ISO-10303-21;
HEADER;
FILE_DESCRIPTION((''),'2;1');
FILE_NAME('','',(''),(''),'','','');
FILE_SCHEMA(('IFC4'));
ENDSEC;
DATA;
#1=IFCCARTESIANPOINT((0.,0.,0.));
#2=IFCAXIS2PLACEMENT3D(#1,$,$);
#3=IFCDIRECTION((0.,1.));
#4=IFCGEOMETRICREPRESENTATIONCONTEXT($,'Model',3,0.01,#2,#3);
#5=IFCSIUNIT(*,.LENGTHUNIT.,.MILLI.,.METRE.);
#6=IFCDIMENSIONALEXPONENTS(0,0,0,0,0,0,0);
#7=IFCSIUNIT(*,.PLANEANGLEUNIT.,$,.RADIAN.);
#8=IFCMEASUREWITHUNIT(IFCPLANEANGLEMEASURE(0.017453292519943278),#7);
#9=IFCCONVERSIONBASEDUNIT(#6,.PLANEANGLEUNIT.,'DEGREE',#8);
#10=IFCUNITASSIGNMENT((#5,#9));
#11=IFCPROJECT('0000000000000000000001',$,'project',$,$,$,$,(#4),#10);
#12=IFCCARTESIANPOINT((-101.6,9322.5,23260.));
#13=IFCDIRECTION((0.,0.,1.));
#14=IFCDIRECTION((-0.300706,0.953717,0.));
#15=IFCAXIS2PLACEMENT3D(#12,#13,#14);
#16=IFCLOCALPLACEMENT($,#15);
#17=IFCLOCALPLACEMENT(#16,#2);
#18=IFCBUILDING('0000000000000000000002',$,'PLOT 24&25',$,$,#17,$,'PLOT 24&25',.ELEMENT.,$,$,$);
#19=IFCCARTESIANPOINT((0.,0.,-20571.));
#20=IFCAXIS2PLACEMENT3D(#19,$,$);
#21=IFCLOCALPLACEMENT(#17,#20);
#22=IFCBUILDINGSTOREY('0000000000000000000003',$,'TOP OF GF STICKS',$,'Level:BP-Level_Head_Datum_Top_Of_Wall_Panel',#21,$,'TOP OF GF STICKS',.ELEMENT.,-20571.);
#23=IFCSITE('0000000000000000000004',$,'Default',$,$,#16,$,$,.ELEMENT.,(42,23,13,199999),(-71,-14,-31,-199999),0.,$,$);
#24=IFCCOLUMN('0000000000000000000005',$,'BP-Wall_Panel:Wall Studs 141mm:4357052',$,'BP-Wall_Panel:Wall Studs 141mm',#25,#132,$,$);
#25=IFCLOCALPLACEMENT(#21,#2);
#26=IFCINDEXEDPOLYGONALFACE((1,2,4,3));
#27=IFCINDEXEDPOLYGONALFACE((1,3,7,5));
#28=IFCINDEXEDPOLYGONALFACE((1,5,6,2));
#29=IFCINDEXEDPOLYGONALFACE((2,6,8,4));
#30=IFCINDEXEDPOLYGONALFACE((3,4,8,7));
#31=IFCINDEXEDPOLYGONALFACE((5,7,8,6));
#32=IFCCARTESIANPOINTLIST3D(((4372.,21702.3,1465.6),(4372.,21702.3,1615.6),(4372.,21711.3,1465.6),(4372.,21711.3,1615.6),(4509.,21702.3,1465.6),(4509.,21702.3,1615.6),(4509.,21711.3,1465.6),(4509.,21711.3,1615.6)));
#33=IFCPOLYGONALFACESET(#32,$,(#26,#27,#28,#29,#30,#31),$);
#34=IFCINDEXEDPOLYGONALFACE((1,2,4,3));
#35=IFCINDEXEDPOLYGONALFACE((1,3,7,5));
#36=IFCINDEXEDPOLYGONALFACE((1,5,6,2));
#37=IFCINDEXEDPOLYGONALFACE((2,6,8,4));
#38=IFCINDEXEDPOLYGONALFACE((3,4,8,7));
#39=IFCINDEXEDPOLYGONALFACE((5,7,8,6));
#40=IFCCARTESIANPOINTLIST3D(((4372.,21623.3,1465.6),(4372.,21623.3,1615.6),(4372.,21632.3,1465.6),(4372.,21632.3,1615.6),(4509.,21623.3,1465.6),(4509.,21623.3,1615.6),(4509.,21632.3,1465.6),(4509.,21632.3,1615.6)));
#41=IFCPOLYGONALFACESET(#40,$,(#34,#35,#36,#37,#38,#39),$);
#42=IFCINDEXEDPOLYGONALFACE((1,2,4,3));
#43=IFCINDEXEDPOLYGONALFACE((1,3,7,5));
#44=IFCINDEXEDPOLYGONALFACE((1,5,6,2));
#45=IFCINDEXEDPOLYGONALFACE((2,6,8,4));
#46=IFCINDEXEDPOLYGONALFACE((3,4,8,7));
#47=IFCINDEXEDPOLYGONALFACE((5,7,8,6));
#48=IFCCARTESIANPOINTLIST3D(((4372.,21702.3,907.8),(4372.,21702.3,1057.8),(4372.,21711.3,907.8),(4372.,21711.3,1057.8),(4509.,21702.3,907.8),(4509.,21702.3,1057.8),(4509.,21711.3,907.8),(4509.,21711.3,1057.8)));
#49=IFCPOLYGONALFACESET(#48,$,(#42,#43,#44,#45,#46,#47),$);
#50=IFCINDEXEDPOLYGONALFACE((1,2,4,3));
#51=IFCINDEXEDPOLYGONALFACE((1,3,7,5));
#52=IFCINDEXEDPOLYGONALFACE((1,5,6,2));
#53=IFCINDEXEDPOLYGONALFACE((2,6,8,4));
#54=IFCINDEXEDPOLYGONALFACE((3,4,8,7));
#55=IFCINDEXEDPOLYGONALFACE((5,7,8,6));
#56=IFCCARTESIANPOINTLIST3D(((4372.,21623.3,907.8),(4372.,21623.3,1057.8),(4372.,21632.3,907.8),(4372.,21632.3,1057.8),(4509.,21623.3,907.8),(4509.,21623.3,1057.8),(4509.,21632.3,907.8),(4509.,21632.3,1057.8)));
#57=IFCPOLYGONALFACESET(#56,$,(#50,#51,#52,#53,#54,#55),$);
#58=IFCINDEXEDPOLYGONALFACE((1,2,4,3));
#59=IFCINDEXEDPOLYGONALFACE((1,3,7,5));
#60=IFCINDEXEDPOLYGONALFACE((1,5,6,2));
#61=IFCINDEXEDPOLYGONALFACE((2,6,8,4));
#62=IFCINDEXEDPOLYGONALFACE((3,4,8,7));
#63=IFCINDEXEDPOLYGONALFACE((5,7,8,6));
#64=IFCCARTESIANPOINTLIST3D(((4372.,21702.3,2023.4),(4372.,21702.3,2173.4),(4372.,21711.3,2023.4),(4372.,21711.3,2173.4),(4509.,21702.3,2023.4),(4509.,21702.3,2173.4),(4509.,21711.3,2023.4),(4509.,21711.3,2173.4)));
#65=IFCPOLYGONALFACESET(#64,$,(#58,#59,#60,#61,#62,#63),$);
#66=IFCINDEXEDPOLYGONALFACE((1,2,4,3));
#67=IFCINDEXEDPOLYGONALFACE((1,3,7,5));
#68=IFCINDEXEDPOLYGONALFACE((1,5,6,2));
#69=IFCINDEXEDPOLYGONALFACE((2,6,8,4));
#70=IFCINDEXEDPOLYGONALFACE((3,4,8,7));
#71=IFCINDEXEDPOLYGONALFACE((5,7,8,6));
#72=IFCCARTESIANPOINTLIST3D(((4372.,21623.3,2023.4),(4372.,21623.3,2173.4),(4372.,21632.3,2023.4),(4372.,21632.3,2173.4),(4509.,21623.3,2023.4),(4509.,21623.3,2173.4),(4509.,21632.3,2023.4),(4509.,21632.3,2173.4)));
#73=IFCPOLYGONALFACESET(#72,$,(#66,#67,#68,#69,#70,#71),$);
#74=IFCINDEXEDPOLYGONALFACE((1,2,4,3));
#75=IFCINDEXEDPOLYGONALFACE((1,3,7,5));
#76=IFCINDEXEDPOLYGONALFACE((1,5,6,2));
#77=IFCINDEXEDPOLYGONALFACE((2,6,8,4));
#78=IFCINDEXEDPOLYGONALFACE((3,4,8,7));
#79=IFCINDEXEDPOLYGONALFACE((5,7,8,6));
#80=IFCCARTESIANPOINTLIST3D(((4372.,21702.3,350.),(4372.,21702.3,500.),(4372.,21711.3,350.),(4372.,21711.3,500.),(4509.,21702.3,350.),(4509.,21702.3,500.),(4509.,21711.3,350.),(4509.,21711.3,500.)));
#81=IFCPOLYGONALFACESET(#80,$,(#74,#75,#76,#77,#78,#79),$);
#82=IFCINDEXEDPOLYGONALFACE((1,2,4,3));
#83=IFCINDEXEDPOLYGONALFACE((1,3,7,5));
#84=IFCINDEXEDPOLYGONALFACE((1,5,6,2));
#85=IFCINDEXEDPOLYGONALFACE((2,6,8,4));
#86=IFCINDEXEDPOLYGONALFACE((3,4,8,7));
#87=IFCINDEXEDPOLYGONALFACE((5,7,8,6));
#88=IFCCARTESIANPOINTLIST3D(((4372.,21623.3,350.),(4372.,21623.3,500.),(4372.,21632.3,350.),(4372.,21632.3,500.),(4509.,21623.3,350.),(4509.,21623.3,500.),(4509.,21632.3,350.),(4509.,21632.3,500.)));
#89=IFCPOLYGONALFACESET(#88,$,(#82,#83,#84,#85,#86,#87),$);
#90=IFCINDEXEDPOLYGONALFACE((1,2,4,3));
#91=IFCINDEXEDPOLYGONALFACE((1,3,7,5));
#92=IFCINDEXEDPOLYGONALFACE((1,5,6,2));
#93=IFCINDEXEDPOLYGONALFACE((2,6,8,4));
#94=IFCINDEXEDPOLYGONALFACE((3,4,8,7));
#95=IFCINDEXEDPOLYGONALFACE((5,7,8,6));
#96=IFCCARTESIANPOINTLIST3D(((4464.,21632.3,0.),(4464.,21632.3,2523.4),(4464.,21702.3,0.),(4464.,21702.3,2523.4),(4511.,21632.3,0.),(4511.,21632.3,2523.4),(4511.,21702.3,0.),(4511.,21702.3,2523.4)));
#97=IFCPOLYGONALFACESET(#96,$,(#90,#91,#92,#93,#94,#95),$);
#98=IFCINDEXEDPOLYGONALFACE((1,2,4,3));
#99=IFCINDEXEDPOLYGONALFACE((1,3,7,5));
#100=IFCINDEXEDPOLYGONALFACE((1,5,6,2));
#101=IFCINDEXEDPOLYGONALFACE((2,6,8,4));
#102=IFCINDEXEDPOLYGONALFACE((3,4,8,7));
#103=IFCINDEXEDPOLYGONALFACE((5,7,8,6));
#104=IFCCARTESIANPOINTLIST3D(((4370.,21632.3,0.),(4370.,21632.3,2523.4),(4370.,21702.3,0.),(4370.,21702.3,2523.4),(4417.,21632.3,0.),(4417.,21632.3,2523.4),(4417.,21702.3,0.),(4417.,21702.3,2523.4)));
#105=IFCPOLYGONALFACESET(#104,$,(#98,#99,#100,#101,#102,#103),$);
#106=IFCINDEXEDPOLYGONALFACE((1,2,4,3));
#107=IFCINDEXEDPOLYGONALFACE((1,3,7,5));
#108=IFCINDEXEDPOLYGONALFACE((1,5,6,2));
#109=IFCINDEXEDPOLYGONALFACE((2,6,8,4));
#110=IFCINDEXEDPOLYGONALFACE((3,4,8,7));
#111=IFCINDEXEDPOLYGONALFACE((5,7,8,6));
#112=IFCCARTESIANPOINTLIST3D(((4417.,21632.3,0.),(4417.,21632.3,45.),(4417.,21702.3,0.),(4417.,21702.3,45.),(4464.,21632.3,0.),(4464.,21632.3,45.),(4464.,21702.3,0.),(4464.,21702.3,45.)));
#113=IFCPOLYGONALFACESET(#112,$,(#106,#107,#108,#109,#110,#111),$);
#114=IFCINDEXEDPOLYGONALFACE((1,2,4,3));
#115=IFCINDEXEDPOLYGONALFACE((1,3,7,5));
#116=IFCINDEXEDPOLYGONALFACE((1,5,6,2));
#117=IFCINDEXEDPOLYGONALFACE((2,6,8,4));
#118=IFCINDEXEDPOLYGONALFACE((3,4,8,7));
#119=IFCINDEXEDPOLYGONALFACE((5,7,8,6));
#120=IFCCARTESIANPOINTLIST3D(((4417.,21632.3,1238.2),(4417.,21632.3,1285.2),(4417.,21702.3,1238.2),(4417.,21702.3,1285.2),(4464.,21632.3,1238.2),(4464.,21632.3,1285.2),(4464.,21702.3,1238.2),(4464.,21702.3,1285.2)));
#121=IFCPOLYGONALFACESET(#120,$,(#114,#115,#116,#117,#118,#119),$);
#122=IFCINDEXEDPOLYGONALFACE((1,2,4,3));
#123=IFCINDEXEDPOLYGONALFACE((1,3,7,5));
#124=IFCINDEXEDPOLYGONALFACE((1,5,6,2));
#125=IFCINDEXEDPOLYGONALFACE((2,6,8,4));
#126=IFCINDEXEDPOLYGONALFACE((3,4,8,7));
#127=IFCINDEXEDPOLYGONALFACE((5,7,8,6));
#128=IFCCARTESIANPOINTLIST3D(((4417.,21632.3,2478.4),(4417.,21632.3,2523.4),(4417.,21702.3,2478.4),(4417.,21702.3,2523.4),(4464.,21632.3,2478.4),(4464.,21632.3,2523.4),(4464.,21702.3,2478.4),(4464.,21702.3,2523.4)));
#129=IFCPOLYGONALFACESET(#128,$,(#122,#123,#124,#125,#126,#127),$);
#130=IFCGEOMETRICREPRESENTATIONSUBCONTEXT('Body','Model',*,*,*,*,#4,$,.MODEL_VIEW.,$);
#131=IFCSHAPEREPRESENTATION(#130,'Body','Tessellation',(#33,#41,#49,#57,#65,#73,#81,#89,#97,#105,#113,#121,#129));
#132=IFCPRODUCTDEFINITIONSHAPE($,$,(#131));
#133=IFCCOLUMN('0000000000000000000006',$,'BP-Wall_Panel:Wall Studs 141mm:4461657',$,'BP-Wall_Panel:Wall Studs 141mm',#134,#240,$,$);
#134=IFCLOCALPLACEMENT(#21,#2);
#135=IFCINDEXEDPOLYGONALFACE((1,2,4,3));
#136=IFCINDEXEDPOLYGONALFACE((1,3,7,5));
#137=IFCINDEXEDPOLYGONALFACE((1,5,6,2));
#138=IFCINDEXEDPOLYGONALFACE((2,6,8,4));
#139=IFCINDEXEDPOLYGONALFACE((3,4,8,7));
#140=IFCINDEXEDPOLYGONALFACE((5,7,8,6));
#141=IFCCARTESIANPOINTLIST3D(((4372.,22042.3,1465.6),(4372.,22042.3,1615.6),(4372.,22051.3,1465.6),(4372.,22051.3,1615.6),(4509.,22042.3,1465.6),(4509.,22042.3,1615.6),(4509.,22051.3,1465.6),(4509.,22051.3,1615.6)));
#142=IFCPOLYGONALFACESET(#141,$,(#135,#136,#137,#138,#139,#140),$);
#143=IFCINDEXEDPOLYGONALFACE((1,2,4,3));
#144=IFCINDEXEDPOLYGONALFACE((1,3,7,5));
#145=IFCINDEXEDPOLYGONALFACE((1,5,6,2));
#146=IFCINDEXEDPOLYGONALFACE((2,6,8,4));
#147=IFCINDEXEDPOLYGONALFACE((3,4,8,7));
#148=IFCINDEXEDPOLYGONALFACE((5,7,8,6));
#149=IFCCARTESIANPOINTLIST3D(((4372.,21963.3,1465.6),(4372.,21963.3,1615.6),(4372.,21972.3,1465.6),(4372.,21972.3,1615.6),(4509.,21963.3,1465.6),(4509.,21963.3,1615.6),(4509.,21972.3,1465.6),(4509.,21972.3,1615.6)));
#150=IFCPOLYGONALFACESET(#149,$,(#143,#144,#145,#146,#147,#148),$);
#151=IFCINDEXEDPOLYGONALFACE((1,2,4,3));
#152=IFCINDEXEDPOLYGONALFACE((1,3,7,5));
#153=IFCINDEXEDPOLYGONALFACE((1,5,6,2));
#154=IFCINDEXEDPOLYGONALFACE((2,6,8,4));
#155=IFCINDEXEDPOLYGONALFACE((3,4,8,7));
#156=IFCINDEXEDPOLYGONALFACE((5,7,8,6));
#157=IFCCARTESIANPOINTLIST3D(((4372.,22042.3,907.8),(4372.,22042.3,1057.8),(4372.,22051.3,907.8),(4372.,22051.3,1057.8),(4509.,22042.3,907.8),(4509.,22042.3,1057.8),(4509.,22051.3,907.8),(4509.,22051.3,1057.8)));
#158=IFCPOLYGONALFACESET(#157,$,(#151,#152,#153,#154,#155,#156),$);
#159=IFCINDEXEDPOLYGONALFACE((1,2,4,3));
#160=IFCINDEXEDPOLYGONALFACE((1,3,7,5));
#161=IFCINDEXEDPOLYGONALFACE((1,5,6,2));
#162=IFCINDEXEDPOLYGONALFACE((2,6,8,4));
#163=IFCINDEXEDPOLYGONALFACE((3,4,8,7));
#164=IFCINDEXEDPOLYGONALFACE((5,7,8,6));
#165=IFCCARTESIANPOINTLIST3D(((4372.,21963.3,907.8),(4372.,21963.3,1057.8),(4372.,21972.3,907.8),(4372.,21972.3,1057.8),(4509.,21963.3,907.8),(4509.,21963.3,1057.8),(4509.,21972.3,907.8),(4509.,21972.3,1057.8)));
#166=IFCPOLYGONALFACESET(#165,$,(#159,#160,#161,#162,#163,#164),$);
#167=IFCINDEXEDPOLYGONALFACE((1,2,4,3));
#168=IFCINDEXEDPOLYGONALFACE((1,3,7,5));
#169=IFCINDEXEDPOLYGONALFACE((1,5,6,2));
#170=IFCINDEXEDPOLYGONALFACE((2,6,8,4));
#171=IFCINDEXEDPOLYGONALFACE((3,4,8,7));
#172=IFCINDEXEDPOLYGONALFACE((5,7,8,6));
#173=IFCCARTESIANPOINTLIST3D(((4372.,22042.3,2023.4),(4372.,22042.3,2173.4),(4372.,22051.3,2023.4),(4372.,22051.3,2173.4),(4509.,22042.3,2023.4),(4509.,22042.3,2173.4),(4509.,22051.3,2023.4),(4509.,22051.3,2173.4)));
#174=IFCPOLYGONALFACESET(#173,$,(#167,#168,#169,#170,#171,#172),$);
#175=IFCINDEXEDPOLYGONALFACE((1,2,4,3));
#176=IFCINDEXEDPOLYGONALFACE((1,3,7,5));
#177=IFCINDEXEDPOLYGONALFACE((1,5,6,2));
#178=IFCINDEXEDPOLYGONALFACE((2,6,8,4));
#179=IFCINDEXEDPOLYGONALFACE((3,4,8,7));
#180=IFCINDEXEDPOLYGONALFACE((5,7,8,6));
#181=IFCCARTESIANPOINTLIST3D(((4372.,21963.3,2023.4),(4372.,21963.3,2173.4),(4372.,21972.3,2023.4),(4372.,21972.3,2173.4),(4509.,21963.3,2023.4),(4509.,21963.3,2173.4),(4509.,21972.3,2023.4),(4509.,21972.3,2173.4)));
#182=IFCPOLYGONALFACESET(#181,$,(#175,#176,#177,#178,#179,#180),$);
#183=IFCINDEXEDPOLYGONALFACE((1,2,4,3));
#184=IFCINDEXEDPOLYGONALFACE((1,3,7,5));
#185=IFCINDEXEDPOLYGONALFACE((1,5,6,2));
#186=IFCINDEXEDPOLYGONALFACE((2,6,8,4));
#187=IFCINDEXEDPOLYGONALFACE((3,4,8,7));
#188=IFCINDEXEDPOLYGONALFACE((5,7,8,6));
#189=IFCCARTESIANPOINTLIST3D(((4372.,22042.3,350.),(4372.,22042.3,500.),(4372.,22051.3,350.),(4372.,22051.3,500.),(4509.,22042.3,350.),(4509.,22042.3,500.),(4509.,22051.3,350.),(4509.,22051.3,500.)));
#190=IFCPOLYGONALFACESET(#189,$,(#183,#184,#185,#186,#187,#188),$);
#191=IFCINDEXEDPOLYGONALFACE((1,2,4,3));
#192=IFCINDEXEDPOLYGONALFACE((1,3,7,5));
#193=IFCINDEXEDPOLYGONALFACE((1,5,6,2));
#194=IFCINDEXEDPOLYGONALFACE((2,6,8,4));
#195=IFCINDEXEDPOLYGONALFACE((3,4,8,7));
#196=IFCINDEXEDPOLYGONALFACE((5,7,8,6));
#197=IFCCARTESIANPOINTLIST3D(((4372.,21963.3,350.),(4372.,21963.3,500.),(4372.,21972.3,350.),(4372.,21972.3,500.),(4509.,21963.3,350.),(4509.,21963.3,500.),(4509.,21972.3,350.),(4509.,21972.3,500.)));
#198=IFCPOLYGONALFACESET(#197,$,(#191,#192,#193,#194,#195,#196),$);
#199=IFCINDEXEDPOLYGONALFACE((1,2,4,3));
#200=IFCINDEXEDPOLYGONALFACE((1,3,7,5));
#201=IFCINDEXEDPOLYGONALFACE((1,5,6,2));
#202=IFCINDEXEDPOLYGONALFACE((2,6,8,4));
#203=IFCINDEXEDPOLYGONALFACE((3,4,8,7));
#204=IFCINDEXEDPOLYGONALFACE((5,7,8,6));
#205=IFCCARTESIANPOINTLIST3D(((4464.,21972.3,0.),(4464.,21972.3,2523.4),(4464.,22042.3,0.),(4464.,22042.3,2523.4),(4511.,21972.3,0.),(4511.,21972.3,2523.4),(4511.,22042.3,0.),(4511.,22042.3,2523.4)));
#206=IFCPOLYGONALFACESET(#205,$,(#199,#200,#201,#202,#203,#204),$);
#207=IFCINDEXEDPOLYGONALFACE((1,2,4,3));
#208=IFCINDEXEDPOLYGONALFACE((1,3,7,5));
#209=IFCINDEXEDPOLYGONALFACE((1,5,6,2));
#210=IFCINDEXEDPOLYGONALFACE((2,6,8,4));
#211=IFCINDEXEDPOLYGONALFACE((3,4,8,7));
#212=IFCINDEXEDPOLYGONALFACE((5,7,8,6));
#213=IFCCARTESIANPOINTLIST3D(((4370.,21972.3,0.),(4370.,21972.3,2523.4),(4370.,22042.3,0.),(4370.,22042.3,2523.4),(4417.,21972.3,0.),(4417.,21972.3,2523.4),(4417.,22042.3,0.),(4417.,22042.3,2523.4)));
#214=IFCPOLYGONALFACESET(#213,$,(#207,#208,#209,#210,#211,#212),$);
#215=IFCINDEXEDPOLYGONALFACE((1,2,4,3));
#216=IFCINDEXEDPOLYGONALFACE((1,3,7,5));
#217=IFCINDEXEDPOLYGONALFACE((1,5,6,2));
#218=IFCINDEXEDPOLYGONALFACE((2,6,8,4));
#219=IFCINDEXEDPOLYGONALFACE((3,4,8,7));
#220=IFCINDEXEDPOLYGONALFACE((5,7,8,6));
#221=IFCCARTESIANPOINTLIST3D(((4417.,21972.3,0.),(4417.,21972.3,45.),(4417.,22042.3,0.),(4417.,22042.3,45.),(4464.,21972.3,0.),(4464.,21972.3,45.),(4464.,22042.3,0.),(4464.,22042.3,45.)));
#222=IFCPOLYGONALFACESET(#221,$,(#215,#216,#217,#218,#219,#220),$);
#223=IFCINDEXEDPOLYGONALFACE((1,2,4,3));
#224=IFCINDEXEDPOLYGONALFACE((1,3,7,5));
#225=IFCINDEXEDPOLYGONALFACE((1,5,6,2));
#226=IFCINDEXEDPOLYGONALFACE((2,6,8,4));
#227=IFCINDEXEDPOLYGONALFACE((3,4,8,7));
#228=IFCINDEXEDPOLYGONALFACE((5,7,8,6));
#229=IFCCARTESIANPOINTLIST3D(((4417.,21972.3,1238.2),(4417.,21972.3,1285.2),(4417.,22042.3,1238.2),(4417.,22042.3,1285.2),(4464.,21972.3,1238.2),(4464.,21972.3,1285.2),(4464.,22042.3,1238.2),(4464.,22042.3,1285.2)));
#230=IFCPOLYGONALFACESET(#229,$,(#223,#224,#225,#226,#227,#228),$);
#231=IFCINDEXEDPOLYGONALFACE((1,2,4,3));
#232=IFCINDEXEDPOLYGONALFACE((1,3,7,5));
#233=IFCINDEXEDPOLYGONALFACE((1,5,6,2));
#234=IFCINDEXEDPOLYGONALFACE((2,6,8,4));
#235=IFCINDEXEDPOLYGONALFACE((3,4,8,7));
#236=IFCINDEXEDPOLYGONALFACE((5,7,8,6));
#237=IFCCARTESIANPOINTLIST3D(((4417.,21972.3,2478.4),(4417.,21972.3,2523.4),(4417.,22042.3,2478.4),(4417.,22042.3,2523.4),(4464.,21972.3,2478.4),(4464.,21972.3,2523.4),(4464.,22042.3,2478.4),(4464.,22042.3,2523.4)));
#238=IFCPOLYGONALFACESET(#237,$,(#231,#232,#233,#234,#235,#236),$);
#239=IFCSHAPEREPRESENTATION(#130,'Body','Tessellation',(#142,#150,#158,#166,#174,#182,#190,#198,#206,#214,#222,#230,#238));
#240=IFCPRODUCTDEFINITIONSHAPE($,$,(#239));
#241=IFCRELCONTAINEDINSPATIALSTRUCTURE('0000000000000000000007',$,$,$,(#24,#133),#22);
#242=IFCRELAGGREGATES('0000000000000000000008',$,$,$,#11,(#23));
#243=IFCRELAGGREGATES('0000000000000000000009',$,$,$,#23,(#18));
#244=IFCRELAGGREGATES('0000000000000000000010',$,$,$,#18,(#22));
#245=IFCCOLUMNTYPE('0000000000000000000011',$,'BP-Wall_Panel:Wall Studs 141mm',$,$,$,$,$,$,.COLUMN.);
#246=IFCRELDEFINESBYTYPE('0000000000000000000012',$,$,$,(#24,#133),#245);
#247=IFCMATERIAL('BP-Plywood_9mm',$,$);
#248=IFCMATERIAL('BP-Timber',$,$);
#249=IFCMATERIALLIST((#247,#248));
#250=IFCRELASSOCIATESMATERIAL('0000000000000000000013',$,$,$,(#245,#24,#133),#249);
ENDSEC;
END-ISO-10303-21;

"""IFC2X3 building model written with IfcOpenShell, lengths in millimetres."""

from ifc_helpers import new_model, entity, si_unit, converted_unit, direction, frame, frame_2d, origin, origin_2d_with_axis, place, context, subcontext, project, spatial, rectangle, extrude, source, transform, mapped, material, material_list, type_object, type_shapes, element, save


model = new_model("IFC2X3")

# Units and contexts
model_context = context("Model", 3, precision=0.01, world=origin(), true_north=direction((0.0, 1.0)))
body_context = subcontext(model_context, "Body", "Model", "MODEL_VIEW")
ifc_project = project(units=[si_unit("LENGTHUNIT", "METRE", prefix="MILLI"), converted_unit("PLANEANGLEUNIT", "DEGREE", entity("IfcPlaneAngleMeasure", 0.017453292519943278), si_unit("PLANEANGLEUNIT", "RADIAN"), dimensions=[0, 0, 0, 0, 0, 0, 0])], contexts=[model_context])

# Site, building, storey
site_placement = place(None, frame((-101.6, 9322.5, 23260.0), z_axis=(0.0, 0.0, 1.0), x_axis=(-0.300706, 0.953717, 0.0)))
site = spatial("IfcSite", under=ifc_project, at=site_placement, Name="Default", CompositionType="ELEMENT", RefLatitude=(42, 23, 13, 199999), RefLongitude=(-71, -14, -31, -199999), RefElevation=0.0)
building_placement = place(site_placement, origin())
building = spatial("IfcBuilding", under=site, at=building_placement, Name="PLOT 24&25", LongName="PLOT 24&25", CompositionType="ELEMENT")
storey_placement = place(building_placement, frame((0.0, 0.0, -20571.0)))
storey = spatial("IfcBuildingStorey", under=building, at=storey_placement, Name="TOP OF GF STICKS", ObjectType="Level:BP-Level_Head_Datum_Top_Of_Wall_Panel", LongName="TOP OF GF STICKS", CompositionType="ELEMENT", Elevation=-20571.0)

# Columns
ifc_material_1 = material(Name="BP-Plywood_9mm")
ifc_material_2 = material(Name="BP-Timber")
ifc_material_list = material_list([ifc_material_1, ifc_material_2])
column_type_1 = type_object("IfcColumnType", Name="BP-Wall_Panel:Wall Studs 141mm", PredefinedType="COLUMN", material=ifc_material_list)
shared_shape_1 = source(origin(), body_context, "Body", "SweptSolid", [
    extrude(rectangle(XDim=137.0, YDim=9.0, at=origin_2d_with_axis()), frame((39.5, 0.0, -19105.4), z_axis=(0.0, 0.0, 1.0), x_axis=(0.0, -1.0, 0.0)), (0.0, 0.0, 1.0), 150.0),
    extrude(rectangle(XDim=9.0, YDim=137.0, at=origin_2d_with_axis()), frame((-39.5, 0.0, -19105.4), z_axis=(0.0, 0.0, 1.0), x_axis=(-1.0, 0.0, 0.0)), (0.0, 0.0, 1.0), 150.0),
    extrude(rectangle(XDim=137.0, YDim=9.0, at=origin_2d_with_axis()), frame((39.5, 0.0, -19663.2), z_axis=(0.0, 0.0, 1.0), x_axis=(0.0, -1.0, 0.0)), (0.0, 0.0, 1.0), 150.0),
    extrude(rectangle(XDim=9.0, YDim=137.0, at=origin_2d_with_axis()), frame((-39.5, 0.0, -19663.2), z_axis=(0.0, 0.0, 1.0), x_axis=(-1.0, 0.0, 0.0)), (0.0, 0.0, 1.0), 150.0),
    extrude(rectangle(XDim=137.0, YDim=9.0, at=frame_2d((0.0, 0.0), x_axis=(1.0, 0.0))), frame((39.5, 0.0, -18547.6), z_axis=(0.0, 0.0, 1.0), x_axis=(0.0, -1.0, 0.0)), (0.0, 0.0, 1.0), 150.0),
    extrude(rectangle(XDim=9.0, YDim=137.0, at=origin_2d_with_axis()), frame((-39.5, 0.0, -18547.6), z_axis=(0.0, 0.0, 1.0), x_axis=(-1.0, 0.0, 0.0)), (0.0, 0.0, 1.0), 150.0),
    extrude(rectangle(XDim=137.0, YDim=9.0, at=origin_2d_with_axis()), frame((39.5, 0.0, -20221.0), z_axis=(0.0, 0.0, 1.0), x_axis=(0.0, -1.0, 0.0)), (0.0, 0.0, 1.0), 150.0),
    extrude(rectangle(XDim=9.0, YDim=137.0, at=origin_2d_with_axis()), frame((-39.5, 0.0, -20221.0), z_axis=(0.0, 0.0, 1.0), x_axis=(-1.0, 0.0, 0.0)), (0.0, 0.0, 1.0), 150.0),
    extrude(rectangle(XDim=70.0, YDim=47.0, at=origin_2d_with_axis()), frame((0.0, -47.0, -20571.0), z_axis=(0.0, 0.0, 1.0), x_axis=(-1.0, 0.0, 0.0)), (0.0, 0.0, 1.0), 2523.4),
    extrude(rectangle(XDim=70.0, YDim=47.0, at=origin_2d_with_axis()), frame((0.0, 47.0, -20571.0), z_axis=(0.0, 0.0, 1.0), x_axis=(-1.0, 0.0, 0.0)), (0.0, 0.0, 1.0), 2523.4),
    extrude(rectangle(XDim=47.0, YDim=70.0, at=origin_2d_with_axis()), frame((0.0, 0.0, -20571.0), z_axis=(0.0, 0.0, 1.0), x_axis=(0.0, -1.0, 0.0)), (0.0, 0.0, 1.0), 45.0),
    extrude(rectangle(XDim=47.0, YDim=70.0, at=origin_2d_with_axis()), frame((0.0, 0.0, -19332.8), z_axis=(0.0, 0.0, 1.0), x_axis=(0.0, -1.0, 0.0)), (0.0, 0.0, 1.0), 47.0),
    extrude(rectangle(XDim=47.0, YDim=70.0, at=origin_2d_with_axis()), frame((0.0, 0.0, -18092.6), z_axis=(0.0, 0.0, 1.0), x_axis=(0.0, -1.0, 0.0)), (0.0, 0.0, 1.0), 45.0),
])
type_shapes(column_type_1, [shared_shape_1])
for number, where, z_axis, x_axis, name in (
    (1, (4440.5, 21667.3, 20571.0), (0.0, 0.0, 1.0), (0.0, 1.0, 0.0), "BP-Wall_Panel:Wall Studs 141mm:4357052"),
    (2, (4440.5, 22007.3, 20571.0), (0.0, 0.0, 1.0), (0.0, 1.0, 0.0), "BP-Wall_Panel:Wall Studs 141mm:4461657"),
):
    element("IfcColumn", number, at=place(storey_placement, frame(where, z_axis=z_axis, x_axis=x_axis)), inside=storey, type_object=column_type_1, material=ifc_material_list, Name=name, ObjectType="BP-Wall_Panel:Wall Studs 141mm", context=body_context, shape_type="MappedRepresentation", body=[
        mapped(shared_shape_1, transform((0.0, 0.0, 0.0), scale=1.0)),
    ])

save(model, "model.ifc")
